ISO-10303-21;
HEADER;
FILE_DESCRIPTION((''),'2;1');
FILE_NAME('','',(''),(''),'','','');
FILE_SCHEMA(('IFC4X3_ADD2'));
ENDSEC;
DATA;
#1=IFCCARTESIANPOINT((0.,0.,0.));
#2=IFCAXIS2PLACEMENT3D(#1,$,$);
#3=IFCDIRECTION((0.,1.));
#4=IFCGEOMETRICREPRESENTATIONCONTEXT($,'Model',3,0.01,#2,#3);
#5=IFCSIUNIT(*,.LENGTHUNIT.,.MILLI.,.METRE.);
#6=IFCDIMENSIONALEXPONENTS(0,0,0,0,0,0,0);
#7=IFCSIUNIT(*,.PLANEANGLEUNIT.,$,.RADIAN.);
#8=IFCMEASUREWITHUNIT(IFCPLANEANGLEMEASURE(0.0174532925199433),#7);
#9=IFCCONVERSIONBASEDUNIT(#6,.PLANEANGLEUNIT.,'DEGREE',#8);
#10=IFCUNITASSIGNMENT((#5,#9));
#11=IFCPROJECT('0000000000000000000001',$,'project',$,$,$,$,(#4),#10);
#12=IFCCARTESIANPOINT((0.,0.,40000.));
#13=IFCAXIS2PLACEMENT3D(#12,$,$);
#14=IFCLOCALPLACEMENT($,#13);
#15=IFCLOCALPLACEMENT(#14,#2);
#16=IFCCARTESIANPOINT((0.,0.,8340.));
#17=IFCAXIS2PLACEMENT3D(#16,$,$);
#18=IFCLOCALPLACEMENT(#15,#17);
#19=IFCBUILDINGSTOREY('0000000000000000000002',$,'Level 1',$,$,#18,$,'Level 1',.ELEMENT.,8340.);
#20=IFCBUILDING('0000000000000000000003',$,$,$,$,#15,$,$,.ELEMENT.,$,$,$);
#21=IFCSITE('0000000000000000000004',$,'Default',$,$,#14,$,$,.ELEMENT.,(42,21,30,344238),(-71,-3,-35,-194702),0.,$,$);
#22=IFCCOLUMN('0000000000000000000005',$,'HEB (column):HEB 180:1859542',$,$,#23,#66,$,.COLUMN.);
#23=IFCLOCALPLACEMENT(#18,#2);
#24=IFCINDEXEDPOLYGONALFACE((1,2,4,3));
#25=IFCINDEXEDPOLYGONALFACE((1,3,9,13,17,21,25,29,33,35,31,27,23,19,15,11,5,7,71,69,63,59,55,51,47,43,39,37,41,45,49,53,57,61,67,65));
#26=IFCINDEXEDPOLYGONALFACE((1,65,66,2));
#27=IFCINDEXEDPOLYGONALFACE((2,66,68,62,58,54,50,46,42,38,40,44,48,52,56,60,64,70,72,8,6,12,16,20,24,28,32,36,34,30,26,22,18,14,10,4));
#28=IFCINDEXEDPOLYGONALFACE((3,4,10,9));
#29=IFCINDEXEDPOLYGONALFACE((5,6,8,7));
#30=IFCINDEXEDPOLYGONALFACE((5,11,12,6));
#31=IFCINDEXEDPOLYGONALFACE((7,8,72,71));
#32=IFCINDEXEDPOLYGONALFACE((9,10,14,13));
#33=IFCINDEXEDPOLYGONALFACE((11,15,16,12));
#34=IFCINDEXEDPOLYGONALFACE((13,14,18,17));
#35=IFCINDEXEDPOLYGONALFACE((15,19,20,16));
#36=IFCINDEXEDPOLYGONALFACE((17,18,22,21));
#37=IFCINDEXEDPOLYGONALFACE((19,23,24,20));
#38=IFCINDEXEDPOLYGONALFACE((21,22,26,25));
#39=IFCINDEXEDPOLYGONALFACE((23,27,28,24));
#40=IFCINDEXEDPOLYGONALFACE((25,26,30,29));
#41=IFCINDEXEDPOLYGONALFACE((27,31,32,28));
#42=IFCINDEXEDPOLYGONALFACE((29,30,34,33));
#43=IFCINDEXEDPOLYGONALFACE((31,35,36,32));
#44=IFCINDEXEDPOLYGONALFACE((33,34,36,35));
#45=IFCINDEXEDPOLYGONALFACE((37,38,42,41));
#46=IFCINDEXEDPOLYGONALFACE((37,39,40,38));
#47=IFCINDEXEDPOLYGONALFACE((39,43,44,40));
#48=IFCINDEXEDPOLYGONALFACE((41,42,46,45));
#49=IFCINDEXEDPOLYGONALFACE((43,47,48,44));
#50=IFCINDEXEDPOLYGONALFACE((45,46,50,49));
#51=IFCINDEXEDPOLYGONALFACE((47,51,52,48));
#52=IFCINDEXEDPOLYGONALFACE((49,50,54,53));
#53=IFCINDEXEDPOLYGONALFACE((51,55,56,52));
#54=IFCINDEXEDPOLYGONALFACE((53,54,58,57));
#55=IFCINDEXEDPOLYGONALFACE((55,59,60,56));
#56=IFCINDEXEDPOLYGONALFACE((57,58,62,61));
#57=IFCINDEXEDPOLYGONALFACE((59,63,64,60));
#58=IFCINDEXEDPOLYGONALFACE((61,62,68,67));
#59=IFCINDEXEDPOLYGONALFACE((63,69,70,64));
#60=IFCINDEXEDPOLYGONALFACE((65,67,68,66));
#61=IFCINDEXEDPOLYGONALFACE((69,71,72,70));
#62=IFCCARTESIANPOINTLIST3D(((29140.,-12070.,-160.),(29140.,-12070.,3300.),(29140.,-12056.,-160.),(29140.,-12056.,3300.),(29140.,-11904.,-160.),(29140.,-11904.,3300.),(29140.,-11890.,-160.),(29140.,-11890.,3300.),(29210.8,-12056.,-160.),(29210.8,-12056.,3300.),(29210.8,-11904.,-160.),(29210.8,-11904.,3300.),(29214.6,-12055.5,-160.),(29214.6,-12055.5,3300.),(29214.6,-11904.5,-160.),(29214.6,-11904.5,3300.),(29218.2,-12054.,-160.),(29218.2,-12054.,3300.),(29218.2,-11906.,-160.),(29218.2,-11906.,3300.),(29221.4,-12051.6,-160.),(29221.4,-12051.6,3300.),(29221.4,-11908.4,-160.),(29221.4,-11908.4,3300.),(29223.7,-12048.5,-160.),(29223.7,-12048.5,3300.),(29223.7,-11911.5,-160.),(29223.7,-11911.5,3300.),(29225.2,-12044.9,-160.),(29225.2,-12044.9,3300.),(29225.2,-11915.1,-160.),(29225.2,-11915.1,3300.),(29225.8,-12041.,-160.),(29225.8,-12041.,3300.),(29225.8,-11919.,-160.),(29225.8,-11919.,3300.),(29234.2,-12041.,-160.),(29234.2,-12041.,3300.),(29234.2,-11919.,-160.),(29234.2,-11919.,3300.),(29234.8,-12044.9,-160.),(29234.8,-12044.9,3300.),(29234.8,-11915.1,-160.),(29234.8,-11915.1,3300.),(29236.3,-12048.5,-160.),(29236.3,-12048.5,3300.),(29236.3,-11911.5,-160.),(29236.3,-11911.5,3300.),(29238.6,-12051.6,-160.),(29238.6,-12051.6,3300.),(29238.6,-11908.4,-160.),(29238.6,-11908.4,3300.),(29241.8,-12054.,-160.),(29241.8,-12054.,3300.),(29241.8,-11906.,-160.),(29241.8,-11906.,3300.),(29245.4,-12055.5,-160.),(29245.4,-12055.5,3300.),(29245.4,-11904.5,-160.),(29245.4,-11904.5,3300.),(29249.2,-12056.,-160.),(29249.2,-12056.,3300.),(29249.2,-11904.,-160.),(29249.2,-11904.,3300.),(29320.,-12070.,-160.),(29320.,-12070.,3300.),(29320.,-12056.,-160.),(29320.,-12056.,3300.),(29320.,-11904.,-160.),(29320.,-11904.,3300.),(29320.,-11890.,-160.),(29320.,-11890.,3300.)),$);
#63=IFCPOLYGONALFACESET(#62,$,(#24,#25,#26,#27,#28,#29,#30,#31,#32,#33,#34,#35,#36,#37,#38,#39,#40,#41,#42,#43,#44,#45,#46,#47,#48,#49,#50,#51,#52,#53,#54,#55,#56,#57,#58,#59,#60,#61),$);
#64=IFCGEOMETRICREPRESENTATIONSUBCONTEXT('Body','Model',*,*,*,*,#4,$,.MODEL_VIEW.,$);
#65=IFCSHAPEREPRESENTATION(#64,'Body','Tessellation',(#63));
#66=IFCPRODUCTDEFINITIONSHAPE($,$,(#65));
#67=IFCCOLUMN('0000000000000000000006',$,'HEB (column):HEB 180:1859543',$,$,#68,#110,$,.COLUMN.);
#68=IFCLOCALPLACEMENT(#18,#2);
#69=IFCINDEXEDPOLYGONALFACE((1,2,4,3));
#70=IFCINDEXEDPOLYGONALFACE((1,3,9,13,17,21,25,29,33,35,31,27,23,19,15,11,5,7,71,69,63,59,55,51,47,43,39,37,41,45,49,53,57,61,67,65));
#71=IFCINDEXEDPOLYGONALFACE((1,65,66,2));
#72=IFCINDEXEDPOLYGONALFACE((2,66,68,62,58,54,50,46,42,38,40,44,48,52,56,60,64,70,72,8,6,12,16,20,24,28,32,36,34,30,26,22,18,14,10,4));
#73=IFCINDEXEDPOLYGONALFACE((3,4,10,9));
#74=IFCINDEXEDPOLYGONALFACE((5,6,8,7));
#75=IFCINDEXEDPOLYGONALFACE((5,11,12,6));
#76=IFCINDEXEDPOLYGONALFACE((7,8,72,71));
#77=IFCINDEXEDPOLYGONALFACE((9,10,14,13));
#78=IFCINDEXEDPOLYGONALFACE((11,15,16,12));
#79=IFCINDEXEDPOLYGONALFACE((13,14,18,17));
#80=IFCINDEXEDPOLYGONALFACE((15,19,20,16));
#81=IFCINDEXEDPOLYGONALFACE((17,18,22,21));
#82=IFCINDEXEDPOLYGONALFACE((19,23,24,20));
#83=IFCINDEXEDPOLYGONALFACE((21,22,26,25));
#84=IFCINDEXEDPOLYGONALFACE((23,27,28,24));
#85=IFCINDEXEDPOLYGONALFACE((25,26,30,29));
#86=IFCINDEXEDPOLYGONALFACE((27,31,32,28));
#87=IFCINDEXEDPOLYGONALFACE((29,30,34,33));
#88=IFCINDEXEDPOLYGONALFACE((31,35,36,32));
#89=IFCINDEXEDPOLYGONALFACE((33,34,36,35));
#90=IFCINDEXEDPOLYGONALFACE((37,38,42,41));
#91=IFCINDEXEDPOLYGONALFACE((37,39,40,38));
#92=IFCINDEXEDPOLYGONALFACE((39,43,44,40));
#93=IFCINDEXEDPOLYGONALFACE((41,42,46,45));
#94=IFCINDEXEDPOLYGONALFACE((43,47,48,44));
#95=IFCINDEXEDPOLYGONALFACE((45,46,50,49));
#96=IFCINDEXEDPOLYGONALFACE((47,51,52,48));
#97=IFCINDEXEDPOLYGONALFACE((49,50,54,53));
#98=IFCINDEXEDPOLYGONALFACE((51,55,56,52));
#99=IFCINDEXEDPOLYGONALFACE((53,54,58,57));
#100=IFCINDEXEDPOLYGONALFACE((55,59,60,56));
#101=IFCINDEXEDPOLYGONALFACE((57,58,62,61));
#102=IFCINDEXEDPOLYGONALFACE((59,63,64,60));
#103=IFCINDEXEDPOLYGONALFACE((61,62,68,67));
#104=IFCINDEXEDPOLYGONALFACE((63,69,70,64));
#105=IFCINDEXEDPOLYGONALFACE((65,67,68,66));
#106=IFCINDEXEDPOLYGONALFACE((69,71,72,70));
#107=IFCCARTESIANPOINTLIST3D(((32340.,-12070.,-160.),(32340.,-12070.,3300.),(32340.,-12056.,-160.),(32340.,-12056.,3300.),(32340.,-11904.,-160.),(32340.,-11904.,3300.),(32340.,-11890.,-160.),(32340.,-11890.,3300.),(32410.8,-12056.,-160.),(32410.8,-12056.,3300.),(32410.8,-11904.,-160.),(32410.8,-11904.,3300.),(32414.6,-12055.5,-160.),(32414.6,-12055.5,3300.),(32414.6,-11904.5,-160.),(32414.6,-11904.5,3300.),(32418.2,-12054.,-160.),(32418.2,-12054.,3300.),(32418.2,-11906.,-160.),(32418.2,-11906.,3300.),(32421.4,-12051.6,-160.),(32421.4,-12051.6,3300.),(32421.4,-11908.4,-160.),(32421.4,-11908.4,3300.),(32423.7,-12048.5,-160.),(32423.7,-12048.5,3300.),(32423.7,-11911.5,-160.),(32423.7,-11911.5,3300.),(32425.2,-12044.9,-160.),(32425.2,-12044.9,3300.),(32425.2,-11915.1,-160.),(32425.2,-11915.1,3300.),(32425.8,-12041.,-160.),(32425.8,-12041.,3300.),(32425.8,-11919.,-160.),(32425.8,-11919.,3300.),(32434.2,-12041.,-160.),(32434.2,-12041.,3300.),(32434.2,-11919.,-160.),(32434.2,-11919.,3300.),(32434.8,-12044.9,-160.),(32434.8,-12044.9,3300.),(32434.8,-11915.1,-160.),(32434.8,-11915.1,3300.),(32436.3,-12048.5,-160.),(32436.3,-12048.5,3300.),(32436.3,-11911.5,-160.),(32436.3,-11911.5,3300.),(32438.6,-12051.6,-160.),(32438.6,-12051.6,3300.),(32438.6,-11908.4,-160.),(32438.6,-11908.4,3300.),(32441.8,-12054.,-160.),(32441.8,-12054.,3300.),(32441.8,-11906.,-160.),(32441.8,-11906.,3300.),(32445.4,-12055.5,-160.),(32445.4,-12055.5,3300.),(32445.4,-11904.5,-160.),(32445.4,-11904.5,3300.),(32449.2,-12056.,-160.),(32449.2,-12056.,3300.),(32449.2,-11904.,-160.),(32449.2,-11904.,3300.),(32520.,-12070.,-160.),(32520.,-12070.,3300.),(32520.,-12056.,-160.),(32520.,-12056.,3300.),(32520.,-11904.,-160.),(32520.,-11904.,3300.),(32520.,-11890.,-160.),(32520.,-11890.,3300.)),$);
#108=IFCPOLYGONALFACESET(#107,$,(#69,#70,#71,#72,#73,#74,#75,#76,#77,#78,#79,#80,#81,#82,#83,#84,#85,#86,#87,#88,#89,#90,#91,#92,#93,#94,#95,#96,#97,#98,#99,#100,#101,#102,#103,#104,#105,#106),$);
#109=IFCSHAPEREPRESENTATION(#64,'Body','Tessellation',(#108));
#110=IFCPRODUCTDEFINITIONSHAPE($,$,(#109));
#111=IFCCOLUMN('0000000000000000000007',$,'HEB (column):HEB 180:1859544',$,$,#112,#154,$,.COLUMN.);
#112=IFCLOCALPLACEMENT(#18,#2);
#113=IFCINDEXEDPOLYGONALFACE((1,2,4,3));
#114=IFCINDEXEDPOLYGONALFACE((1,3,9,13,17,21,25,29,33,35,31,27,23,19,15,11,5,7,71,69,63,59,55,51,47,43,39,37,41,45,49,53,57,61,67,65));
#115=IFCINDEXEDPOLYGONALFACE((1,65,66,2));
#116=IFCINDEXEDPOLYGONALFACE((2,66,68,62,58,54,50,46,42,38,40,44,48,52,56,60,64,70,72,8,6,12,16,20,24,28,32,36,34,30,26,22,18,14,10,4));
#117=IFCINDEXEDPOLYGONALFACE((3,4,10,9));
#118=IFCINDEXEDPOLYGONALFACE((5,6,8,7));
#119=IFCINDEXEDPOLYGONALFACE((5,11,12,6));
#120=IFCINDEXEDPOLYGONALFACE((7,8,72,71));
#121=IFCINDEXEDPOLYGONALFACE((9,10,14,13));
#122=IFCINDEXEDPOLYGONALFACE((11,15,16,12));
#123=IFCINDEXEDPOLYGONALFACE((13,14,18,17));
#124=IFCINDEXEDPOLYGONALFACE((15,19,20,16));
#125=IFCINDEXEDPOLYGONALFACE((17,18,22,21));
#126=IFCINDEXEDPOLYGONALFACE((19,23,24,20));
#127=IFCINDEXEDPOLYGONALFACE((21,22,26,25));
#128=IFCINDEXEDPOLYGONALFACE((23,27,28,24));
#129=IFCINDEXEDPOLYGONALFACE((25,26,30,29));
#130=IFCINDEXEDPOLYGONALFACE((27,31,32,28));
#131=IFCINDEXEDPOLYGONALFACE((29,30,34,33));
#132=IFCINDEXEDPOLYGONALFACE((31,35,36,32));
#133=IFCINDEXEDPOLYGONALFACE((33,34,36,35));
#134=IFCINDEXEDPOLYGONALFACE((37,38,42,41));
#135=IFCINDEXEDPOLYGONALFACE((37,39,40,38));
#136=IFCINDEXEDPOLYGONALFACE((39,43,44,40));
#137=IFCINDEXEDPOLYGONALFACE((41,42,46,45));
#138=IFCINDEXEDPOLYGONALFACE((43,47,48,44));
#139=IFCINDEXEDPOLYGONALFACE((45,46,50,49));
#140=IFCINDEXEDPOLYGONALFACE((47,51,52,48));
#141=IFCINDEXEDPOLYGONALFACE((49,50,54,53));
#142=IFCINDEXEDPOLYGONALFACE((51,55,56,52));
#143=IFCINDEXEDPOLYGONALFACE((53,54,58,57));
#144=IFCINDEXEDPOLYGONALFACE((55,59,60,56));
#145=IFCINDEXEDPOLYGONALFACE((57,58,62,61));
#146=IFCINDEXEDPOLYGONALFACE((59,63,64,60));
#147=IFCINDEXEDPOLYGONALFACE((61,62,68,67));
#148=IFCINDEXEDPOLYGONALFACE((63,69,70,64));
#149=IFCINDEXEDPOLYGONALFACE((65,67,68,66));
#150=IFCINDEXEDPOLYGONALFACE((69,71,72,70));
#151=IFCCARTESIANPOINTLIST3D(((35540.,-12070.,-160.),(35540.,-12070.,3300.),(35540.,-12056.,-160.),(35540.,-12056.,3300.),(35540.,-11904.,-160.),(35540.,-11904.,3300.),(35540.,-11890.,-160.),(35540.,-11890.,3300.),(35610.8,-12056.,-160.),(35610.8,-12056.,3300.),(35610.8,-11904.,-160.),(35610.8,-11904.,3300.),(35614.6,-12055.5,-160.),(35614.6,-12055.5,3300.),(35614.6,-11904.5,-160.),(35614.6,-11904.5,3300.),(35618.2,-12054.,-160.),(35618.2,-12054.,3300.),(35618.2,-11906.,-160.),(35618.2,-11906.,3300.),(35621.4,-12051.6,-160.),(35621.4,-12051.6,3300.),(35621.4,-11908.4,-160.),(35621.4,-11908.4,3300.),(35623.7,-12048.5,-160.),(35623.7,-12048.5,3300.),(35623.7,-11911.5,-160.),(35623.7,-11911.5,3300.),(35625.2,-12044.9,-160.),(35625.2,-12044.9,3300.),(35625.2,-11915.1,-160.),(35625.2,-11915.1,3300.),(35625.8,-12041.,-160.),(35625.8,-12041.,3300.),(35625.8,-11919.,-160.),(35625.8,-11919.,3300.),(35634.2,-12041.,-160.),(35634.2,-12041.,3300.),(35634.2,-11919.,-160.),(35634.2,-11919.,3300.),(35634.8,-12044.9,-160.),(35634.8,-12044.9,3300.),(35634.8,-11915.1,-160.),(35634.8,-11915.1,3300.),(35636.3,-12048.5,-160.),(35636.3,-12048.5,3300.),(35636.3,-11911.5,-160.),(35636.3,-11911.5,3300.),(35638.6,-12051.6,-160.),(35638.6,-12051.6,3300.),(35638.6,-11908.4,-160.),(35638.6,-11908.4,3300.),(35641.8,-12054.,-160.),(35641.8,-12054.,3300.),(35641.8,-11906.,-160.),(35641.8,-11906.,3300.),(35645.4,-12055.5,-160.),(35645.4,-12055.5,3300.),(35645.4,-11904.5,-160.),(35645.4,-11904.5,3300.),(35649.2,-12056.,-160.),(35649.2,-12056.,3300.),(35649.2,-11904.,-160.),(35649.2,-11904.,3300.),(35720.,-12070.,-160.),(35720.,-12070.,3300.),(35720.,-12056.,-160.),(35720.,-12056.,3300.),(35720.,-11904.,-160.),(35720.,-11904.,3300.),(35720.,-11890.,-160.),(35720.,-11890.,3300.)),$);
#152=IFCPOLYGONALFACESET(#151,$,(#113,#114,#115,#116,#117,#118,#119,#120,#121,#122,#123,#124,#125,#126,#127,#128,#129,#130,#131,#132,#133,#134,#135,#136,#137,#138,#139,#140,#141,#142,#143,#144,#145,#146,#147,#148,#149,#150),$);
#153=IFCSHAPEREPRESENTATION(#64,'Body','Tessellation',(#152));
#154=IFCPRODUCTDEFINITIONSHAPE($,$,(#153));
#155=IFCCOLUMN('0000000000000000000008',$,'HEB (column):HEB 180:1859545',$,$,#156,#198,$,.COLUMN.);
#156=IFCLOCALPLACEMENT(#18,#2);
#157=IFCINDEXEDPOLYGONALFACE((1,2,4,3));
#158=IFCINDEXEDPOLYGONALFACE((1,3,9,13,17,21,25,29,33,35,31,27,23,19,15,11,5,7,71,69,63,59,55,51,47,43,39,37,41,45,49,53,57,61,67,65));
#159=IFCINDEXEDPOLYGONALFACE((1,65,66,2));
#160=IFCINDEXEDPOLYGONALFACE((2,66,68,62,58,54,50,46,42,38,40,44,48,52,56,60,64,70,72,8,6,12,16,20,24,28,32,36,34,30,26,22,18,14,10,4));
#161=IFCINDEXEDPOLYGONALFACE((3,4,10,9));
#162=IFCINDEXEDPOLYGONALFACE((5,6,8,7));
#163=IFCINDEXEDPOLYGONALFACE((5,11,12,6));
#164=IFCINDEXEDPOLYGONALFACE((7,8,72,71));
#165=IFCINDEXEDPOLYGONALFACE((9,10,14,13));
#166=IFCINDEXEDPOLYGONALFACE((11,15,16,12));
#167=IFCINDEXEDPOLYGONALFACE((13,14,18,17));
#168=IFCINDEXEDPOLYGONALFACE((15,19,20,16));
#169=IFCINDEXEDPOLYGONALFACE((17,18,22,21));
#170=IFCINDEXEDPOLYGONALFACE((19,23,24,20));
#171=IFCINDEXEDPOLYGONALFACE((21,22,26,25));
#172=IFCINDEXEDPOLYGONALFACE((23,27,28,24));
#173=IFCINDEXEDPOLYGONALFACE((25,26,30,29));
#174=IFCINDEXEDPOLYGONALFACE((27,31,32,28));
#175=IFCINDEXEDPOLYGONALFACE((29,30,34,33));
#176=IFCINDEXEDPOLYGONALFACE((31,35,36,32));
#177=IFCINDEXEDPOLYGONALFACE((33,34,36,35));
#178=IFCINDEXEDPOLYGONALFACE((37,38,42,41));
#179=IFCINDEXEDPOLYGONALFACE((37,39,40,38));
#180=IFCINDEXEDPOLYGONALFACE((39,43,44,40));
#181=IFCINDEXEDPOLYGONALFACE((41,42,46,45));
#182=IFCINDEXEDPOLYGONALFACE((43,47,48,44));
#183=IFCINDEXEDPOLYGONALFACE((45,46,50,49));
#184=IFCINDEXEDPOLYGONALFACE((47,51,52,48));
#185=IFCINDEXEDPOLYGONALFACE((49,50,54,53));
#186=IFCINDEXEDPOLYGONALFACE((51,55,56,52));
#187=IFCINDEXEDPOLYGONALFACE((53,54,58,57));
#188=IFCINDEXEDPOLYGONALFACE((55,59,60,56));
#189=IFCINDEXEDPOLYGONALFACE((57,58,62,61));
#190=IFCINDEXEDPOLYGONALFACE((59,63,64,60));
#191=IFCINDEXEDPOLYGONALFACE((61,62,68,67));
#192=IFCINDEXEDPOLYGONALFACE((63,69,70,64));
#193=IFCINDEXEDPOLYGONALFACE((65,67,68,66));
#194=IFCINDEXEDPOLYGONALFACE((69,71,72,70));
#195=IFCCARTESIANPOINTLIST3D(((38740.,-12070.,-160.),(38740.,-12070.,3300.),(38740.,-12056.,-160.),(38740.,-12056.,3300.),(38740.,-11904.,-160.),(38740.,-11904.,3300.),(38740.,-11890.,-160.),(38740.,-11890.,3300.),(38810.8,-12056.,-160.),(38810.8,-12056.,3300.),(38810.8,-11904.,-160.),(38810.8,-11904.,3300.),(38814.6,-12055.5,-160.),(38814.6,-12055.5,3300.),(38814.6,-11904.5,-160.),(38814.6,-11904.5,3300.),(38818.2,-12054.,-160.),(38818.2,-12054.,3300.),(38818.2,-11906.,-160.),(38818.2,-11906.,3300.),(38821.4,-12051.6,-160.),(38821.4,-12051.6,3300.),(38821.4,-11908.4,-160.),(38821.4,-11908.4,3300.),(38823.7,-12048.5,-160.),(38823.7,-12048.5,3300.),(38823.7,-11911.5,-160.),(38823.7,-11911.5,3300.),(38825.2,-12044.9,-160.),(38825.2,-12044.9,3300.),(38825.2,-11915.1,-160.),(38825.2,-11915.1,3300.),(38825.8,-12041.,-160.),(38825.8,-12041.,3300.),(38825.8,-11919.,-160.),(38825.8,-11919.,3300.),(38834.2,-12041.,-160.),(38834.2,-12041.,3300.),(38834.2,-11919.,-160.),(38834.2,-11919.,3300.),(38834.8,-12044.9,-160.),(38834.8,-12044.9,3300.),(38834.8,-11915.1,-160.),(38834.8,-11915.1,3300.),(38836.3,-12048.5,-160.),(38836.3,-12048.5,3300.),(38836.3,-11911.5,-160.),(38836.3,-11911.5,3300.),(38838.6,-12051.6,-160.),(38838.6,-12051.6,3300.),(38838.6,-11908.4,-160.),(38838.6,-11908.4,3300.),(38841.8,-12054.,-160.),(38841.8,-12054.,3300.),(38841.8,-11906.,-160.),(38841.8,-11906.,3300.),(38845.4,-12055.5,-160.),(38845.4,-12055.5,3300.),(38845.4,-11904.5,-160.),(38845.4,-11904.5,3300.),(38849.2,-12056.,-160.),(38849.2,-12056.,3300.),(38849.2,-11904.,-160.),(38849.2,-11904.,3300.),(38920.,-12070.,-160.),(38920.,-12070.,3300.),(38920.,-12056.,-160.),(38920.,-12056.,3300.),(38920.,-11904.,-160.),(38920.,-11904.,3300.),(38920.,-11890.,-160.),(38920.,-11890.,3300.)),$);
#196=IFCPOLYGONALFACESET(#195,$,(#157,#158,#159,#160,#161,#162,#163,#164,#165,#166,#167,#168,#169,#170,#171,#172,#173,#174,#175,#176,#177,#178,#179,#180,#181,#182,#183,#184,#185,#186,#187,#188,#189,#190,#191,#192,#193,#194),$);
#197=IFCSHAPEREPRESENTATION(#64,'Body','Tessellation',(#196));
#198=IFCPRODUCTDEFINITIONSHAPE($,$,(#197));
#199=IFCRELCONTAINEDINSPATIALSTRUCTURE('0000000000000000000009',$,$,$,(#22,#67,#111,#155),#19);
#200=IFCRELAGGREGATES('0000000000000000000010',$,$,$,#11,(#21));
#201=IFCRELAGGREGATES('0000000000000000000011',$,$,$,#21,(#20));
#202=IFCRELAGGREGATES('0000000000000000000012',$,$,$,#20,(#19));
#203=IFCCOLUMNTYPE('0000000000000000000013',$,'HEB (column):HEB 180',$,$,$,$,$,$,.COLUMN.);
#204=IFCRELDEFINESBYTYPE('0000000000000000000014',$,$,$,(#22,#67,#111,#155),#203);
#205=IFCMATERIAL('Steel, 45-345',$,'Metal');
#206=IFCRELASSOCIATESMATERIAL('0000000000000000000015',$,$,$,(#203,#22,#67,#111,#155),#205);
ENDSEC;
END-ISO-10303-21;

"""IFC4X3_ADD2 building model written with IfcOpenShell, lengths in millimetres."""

from ifc_helpers import new_model, entity, si_unit, converted_unit, direction, frame, origin, origin_2d_with_axis, place, context, subcontext, project, spatial, i_section, extrude, source, transform, mapped, material, material_profile, profile_set, profile_usage, type_object, type_shapes, element, save


model = new_model("IFC4X3_ADD2")

# Units and contexts
model_context = context("Model", 3, precision=0.01, world=origin(), true_north=direction((0.0, 1.0)))
body_context = subcontext(model_context, "Body", "Model", "MODEL_VIEW")
ifc_project = project(units=[si_unit("LENGTHUNIT", "METRE", prefix="MILLI"), converted_unit("PLANEANGLEUNIT", "DEGREE", entity("IfcPlaneAngleMeasure", 0.0174532925199433), si_unit("PLANEANGLEUNIT", "RADIAN"), dimensions=[0, 0, 0, 0, 0, 0, 0])], contexts=[model_context])

# Site, building, storey
site_placement = place(None, frame((0.0, 0.0, 40000.0)))
site = spatial("IfcSite", under=ifc_project, at=site_placement, Name="Default", CompositionType="ELEMENT", RefLatitude=(42, 21, 30, 344238), RefLongitude=(-71, -3, -35, -194702), RefElevation=0.0)
building_placement = place(site_placement, origin())
building = spatial("IfcBuilding", under=site, at=building_placement, CompositionType="ELEMENT")
storey_placement = place(building_placement, frame((0.0, 0.0, 8340.0)))
storey = spatial("IfcBuildingStorey", under=building, at=storey_placement, Name="Level 1", LongName="Level 1", CompositionType="ELEMENT", Elevation=8340.0)

# Columns
ifc_material = material(Name="Steel, 45-345", Category="Metal")
ifc_material_profile_1 = material_profile(ifc_material, i_section(OverallWidth=180.0, OverallDepth=180.0, WebThickness=8.5, FlangeThickness=14.0, FilletRadius=15.0, at=origin_2d_with_axis()), Name="HEB 180")
ifc_profile_set_1 = profile_set([ifc_material_profile_1], Name="HEB 180")
ifc_profile_usage_1 = profile_usage(ifc_profile_set_1)
column_type_1 = type_object("IfcColumnType", Name="HEB (column):HEB 180", PredefinedType="COLUMN", material=ifc_profile_set_1)
shared_shape_1 = source(origin(), body_context, "Body", "SweptSolid", [
    extrude(i_section(OverallWidth=180.0, OverallDepth=180.0, WebThickness=8.5, FlangeThickness=14.0, FilletRadius=15.0, at=origin_2d_with_axis()), frame((0.0, 0.0, 8180.0), z_axis=(0.0, 0.0, 1.0), x_axis=(-1.0, 0.0, 0.0)), (0.0, 0.0, 1.0), 3460.0),
])
type_shapes(column_type_1, [shared_shape_1])
for number, where, name in (
    (1, (29230.0, -11980.0, -8340.0), "HEB (column):HEB 180:1859542"),
    (2, (32430.0, -11980.0, -8340.0), "HEB (column):HEB 180:1859543"),
    (3, (35630.0, -11980.0, -8340.0), "HEB (column):HEB 180:1859544"),
    (4, (38830.0, -11980.0, -8340.0), "HEB (column):HEB 180:1859545"),
):
    element("IfcColumn", number, at=place(storey_placement, frame(where)), inside=storey, type_object=column_type_1, material=ifc_profile_usage_1, Name=name, PredefinedType="COLUMN", context=body_context, shape_type="MappedRepresentation", body=[
        mapped(shared_shape_1, transform((0.0, 0.0, 0.0), scale=1.0)),
    ])

save(model, "model.ifc")
